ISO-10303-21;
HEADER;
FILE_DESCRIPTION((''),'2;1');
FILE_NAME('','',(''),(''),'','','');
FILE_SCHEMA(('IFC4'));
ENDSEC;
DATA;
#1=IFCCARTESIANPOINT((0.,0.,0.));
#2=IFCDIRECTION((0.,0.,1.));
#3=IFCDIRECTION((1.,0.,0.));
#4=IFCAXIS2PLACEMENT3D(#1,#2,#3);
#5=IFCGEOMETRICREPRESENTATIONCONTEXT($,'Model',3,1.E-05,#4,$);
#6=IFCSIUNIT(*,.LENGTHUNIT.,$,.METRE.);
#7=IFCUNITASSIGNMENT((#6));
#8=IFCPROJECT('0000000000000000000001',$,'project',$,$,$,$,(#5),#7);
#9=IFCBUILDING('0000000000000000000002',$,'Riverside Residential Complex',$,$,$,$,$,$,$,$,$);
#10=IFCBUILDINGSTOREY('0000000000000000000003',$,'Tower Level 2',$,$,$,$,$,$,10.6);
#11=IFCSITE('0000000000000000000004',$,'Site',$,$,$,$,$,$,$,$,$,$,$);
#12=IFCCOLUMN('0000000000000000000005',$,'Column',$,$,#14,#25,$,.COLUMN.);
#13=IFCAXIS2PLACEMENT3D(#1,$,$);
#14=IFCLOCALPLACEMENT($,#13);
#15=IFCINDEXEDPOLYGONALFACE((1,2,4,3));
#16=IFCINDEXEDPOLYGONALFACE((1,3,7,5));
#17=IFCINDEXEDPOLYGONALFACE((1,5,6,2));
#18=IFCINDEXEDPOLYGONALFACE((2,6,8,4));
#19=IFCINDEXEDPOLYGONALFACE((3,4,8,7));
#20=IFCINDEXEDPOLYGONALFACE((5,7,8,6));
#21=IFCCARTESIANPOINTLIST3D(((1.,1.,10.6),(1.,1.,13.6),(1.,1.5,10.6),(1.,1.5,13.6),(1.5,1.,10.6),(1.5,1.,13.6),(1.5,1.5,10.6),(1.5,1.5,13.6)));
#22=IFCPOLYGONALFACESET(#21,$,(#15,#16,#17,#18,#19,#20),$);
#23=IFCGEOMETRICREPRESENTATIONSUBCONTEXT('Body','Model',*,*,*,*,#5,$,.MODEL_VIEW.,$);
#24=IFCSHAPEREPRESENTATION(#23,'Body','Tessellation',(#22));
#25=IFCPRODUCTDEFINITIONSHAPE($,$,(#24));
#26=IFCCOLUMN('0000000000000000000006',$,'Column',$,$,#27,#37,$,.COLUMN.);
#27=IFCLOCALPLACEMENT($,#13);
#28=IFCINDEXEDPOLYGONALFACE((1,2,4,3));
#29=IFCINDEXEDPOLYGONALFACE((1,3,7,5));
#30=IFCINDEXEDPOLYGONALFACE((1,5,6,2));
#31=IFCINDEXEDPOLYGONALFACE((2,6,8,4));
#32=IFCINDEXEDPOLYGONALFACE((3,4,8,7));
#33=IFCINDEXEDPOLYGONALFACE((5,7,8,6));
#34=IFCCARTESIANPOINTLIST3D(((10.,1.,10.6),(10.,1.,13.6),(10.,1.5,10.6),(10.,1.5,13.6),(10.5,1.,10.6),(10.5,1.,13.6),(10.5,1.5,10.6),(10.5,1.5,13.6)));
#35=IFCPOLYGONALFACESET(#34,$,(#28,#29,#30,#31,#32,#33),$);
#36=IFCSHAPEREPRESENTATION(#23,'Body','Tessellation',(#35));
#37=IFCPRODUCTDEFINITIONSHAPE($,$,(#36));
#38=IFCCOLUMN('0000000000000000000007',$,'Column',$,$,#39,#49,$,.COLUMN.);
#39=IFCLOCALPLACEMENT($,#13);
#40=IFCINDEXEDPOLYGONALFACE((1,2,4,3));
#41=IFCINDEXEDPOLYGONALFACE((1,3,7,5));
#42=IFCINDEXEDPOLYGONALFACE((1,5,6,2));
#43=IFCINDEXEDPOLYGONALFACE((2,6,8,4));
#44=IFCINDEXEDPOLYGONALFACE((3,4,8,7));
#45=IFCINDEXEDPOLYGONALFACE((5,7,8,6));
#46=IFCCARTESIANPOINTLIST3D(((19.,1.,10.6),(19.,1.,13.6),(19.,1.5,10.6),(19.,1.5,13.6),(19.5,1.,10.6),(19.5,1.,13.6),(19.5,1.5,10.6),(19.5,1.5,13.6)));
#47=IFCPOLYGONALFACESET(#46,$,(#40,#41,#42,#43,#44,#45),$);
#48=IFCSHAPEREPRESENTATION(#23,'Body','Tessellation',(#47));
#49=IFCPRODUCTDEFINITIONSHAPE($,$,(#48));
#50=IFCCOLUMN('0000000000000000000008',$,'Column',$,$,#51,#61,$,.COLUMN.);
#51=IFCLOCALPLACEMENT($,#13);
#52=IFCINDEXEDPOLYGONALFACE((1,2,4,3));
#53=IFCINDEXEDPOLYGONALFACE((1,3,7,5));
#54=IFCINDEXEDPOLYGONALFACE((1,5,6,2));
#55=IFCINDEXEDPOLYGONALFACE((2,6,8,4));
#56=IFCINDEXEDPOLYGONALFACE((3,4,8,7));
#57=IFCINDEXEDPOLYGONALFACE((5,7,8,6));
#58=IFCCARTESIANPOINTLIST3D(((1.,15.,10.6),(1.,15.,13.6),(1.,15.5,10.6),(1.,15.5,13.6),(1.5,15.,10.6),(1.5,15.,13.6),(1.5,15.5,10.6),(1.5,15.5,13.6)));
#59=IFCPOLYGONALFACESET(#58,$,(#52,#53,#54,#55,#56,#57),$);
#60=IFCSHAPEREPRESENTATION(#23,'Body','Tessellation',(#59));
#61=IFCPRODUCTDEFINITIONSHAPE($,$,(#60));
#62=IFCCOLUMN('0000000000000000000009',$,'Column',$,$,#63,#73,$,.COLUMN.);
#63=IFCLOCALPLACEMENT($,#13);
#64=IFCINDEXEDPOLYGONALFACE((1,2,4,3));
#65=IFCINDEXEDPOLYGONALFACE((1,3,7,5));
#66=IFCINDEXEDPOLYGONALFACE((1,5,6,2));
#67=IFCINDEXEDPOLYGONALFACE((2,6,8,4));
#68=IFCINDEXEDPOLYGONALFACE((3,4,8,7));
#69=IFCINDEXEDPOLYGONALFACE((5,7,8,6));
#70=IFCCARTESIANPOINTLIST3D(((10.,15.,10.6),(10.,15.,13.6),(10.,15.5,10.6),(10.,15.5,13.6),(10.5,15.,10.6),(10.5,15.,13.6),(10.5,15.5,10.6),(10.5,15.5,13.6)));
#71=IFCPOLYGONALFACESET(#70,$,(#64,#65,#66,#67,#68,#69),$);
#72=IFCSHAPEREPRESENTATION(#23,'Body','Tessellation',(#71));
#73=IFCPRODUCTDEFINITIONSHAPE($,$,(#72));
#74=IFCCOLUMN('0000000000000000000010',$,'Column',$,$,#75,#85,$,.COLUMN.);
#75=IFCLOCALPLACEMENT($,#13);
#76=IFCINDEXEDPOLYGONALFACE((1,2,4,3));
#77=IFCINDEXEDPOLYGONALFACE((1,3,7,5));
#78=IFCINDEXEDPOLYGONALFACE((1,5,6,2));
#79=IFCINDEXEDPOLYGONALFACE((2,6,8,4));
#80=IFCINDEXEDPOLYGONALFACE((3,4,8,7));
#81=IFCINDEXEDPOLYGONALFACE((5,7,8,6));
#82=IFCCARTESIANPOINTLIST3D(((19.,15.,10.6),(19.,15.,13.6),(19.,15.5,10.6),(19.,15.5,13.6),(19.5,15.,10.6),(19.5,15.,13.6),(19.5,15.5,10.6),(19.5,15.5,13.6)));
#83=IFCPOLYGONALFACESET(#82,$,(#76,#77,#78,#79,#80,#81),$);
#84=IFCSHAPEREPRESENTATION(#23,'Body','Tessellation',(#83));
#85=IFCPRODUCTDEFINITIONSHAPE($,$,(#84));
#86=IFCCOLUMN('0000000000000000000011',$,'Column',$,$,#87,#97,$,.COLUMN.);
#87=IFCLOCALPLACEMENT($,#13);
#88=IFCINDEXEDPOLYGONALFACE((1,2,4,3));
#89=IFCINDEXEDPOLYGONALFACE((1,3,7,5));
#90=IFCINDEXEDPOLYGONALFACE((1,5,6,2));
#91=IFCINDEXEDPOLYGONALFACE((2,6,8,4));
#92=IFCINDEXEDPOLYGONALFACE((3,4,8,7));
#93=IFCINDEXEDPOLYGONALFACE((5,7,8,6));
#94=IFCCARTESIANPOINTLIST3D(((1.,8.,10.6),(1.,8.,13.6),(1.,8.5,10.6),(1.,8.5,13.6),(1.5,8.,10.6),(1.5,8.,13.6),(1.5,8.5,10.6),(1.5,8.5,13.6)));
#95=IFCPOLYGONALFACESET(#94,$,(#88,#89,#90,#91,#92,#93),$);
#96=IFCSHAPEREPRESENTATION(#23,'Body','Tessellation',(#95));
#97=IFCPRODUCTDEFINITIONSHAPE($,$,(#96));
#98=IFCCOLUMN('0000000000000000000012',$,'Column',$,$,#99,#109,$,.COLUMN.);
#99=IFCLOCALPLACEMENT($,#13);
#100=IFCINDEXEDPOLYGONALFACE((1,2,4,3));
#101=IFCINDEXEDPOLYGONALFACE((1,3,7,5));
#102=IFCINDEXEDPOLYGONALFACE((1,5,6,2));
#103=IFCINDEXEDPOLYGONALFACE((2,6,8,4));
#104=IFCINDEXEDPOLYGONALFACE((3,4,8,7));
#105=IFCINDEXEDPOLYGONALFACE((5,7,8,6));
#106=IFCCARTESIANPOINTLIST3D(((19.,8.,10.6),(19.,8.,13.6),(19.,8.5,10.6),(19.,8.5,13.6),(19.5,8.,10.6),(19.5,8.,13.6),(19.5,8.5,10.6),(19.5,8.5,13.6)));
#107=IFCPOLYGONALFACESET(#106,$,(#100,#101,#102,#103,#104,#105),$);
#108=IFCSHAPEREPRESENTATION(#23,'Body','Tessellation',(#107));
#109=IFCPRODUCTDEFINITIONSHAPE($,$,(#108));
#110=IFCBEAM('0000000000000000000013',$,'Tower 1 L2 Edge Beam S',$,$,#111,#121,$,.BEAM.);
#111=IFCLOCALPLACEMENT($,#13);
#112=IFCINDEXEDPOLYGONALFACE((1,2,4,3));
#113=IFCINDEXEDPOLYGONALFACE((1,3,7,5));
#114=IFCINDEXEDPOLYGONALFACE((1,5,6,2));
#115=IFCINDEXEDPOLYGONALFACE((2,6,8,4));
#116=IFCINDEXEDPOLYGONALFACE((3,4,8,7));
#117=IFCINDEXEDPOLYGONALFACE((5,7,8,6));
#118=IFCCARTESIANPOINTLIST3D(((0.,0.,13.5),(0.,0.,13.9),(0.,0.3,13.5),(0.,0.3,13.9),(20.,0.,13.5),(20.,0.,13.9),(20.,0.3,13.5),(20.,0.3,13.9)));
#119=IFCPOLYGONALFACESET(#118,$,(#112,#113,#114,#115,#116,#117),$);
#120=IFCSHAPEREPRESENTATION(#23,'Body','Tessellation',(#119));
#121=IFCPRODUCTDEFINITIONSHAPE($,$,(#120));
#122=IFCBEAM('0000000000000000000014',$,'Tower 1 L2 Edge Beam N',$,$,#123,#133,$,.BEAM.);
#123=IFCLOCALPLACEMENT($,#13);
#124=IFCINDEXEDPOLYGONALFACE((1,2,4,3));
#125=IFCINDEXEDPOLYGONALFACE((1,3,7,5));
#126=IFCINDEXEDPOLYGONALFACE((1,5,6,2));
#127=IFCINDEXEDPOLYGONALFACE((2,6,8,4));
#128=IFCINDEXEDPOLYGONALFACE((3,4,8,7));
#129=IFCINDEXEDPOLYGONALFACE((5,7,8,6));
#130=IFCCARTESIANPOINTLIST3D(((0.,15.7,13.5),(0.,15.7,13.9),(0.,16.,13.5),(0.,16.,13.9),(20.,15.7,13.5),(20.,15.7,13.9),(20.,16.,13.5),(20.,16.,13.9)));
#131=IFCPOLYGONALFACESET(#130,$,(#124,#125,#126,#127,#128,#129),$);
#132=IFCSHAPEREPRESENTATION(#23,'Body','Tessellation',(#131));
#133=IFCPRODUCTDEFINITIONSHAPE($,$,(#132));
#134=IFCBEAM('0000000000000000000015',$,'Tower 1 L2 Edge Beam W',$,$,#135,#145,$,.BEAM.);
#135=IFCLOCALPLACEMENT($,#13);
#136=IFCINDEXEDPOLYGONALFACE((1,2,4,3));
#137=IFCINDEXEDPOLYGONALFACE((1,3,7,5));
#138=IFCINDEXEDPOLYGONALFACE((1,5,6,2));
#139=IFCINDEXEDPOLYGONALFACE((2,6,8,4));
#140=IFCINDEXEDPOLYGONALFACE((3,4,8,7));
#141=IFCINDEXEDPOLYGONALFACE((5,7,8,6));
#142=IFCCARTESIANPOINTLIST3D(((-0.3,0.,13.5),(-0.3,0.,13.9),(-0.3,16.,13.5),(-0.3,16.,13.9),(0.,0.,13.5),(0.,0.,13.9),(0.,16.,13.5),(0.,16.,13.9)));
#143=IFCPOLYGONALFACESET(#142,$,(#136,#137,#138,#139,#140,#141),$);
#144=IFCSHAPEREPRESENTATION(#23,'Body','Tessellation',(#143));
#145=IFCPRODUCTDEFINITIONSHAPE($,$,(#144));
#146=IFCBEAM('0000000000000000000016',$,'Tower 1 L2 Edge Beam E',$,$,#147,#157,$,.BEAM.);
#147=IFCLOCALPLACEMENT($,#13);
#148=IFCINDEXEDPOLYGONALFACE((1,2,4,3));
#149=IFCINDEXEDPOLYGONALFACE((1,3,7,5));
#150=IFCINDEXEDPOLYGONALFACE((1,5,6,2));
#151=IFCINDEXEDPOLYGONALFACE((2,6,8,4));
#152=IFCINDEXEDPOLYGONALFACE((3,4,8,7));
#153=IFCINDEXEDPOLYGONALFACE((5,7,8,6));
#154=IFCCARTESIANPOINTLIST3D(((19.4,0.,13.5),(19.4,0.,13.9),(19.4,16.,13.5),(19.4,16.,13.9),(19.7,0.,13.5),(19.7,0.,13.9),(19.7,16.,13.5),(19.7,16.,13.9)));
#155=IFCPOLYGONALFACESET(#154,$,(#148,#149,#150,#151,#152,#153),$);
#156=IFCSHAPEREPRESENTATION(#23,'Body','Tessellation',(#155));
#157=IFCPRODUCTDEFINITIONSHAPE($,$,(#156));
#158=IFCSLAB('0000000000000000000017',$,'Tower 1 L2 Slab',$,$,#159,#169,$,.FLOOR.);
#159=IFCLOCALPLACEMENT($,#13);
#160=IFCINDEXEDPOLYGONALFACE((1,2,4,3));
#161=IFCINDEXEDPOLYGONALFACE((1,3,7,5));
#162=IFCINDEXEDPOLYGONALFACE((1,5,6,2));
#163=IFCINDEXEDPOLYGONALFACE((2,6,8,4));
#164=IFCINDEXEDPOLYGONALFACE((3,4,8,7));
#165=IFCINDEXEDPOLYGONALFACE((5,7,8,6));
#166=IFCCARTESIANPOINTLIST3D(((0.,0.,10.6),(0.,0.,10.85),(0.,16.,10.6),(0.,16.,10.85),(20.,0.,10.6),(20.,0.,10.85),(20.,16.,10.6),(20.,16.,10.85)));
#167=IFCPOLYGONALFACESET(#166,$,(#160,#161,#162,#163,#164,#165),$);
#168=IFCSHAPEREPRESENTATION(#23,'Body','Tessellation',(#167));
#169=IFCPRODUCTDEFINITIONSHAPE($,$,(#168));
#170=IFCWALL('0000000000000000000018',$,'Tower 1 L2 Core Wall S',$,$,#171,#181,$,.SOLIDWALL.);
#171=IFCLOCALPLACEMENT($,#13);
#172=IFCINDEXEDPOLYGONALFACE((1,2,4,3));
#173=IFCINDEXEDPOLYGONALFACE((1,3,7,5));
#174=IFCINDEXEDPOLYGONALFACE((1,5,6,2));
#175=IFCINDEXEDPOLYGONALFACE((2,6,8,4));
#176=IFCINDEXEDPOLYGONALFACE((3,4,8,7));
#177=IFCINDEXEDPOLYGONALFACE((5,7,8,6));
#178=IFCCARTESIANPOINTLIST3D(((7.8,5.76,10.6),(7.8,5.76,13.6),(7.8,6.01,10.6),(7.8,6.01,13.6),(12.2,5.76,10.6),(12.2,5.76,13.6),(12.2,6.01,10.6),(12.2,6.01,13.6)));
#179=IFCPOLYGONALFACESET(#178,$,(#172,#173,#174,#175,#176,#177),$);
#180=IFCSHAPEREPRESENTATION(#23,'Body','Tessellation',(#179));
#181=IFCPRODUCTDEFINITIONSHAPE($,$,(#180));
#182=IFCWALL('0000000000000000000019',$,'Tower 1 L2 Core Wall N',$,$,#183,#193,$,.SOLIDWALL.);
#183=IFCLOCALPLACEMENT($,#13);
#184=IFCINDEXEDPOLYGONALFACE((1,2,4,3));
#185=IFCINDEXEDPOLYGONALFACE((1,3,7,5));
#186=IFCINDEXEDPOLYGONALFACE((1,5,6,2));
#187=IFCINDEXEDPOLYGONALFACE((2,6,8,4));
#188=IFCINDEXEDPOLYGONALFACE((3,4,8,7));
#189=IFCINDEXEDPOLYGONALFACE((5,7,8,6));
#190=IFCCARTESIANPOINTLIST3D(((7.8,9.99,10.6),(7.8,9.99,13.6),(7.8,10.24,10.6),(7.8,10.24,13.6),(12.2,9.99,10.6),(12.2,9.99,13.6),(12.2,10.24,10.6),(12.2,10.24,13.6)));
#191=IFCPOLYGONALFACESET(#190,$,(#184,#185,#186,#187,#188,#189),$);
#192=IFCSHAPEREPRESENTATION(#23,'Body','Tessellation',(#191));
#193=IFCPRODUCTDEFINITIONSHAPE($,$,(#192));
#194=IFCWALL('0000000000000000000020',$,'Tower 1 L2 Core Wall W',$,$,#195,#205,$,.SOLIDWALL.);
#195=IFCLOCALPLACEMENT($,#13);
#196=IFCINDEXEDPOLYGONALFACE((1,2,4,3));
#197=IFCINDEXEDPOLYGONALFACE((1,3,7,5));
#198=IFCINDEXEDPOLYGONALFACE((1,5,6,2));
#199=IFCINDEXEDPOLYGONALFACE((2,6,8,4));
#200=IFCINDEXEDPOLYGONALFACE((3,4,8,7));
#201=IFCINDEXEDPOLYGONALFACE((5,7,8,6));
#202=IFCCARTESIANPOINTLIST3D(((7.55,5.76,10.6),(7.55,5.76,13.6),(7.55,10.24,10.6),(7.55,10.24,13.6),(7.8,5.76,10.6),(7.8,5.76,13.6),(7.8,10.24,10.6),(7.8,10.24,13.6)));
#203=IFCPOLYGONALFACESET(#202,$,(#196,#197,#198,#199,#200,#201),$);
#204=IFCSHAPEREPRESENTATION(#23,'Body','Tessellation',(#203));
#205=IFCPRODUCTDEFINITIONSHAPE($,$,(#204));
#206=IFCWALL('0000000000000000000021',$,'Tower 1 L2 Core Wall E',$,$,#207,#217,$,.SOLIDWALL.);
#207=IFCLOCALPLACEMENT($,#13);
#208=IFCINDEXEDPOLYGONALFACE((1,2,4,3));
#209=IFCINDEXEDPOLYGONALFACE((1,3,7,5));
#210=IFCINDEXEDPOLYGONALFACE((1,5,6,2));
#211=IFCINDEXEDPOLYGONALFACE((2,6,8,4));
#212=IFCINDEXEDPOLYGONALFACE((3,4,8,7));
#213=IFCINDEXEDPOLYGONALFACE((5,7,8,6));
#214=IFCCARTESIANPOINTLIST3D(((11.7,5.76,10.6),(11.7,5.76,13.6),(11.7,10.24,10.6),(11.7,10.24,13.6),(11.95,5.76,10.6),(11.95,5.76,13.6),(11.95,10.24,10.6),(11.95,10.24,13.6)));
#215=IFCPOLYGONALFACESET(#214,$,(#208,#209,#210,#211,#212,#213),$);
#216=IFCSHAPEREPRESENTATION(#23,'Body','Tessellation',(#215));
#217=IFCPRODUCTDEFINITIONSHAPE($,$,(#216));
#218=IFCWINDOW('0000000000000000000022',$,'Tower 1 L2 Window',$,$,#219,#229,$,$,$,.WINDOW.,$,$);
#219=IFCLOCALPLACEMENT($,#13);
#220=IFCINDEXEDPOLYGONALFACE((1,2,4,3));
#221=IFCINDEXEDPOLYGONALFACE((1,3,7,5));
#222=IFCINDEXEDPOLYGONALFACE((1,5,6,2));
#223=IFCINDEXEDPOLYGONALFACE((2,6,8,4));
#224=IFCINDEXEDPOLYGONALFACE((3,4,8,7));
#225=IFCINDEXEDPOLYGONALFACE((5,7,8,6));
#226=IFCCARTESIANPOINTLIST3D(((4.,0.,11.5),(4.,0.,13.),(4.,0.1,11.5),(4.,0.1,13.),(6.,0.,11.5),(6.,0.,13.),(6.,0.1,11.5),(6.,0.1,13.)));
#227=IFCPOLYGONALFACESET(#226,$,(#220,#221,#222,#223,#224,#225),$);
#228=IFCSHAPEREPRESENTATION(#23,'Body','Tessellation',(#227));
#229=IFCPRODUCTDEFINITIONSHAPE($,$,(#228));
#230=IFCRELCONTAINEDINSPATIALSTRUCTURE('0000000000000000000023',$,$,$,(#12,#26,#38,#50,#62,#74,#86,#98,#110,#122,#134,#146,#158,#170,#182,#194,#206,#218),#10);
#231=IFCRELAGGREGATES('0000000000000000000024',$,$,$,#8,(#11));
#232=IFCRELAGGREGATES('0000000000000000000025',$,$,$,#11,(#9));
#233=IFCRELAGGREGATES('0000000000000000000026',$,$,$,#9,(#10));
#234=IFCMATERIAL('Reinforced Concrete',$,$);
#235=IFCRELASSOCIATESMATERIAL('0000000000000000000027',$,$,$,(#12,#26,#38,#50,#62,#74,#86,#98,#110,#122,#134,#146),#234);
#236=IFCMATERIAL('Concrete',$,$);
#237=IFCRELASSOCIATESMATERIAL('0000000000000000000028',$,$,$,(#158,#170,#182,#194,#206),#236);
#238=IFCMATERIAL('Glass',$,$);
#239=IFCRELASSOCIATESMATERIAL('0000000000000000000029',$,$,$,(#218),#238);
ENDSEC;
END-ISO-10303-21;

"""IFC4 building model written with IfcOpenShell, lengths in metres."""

from ifc_helpers import new_model, si_unit, frame, origin_with_axes, place, context, subcontext, project, spatial, line, indexed_curve, outline, extrude, material, element, save


model = new_model("IFC4")

# Units and contexts
model_context = context("Model", 3, precision=1e-05, world=origin_with_axes())
body_context = subcontext(model_context, "Body", "Model", "MODEL_VIEW")
ifc_project = project(units=[si_unit("LENGTHUNIT", "METRE")], contexts=[model_context])

# Site, building, storey
site = spatial("IfcSite", under=ifc_project, Name="Site")
building = spatial("IfcBuilding", under=site, Name="Riverside Residential Complex")
storey = spatial("IfcBuildingStorey", under=building, Name="Tower Level 2", Elevation=10.6)

# Columns
ifc_material_1 = material(Name="Reinforced Concrete")
for number, where, z_axis, x_axis, name in (
    (1, (1.0, 1.0, 10.6), (0.0, 0.0, 1.0), (1.0, 0.0, 0.0), "Column"),
    (2, (10.0, 1.0, 10.6), (0.0, 0.0, 1.0), (1.0, 0.0, 0.0), "Column"),
    (3, (19.0, 1.0, 10.6), (0.0, 0.0, 1.0), (1.0, 0.0, 0.0), "Column"),
    (4, (1.0, 15.0, 10.6), (0.0, 0.0, 1.0), (1.0, 0.0, 0.0), "Column"),
    (5, (10.0, 15.0, 10.6), (0.0, 0.0, 1.0), (1.0, 0.0, 0.0), "Column"),
    (6, (19.0, 15.0, 10.6), (0.0, 0.0, 1.0), (1.0, 0.0, 0.0), "Column"),
    (7, (1.0, 8.0, 10.6), (0.0, 0.0, 1.0), (1.0, 0.0, 0.0), "Column"),
    (8, (19.0, 8.0, 10.6), (0.0, 0.0, 1.0), (1.0, 0.0, 0.0), "Column"),
):
    element("IfcColumn", number, at=place(None, frame(where, z_axis=z_axis, x_axis=x_axis)), inside=storey, material=ifc_material_1, Name=name, PredefinedType="COLUMN", context=body_context, shape_type="SweptSolid", body=[
        extrude(outline(indexed_curve([(0.0, 0.0), (0.5, 0.0), (0.5, 0.5), (0.0, 0.5)], segments=[line(1, 2, 3, 4, 1)])), origin_with_axes(), (0.0, 0.0, 1.0), 3.0),
    ])

# Beams
for number, where, z_axis, x_axis, name in (
    (9, (0.0, 0.0, 13.5), (0.0, 0.0, 1.0), (1.0, 0.0, 0.0), "Tower 1 L2 Edge Beam S"),
    (10, (0.0, 15.7, 13.5), (0.0, 0.0, 1.0), (1.0, 0.0, 0.0), "Tower 1 L2 Edge Beam N"),
):
    element("IfcBeam", number, at=place(None, frame(where, z_axis=z_axis, x_axis=x_axis)), inside=storey, material=ifc_material_1, Name=name, PredefinedType="BEAM", context=body_context, shape_type="SweptSolid", body=[
        extrude(outline(indexed_curve([(0.0, 0.0), (20.0, 0.0), (20.0, 0.3), (0.0, 0.3)], segments=[line(1, 2, 3, 4, 1)])), origin_with_axes(), (0.0, 0.0, 1.0), 0.4),
    ])
for number, where, z_axis, x_axis, name in (
    (11, (0.0, 0.0, 13.5), (0.0, 0.0, 1.0), (0.0, 1.0, 0.0), "Tower 1 L2 Edge Beam W"),
    (12, (19.7, 0.0, 13.5), (0.0, 0.0, 1.0), (0.0, 1.0, 0.0), "Tower 1 L2 Edge Beam E"),
):
    element("IfcBeam", number, at=place(None, frame(where, z_axis=z_axis, x_axis=x_axis)), inside=storey, material=ifc_material_1, Name=name, PredefinedType="BEAM", context=body_context, shape_type="SweptSolid", body=[
        extrude(outline(indexed_curve([(0.0, 0.0), (16.0, 0.0), (16.0, 0.3), (0.0, 0.3)], segments=[line(1, 2, 3, 4, 1)])), origin_with_axes(), (0.0, 0.0, 1.0), 0.4),
    ])

# Slab
ifc_material_2 = material(Name="Concrete")
slab_placement = place(None, frame((0.0, 0.0, 10.6), z_axis=(0.0, 0.0, 1.0), x_axis=(1.0, 0.0, 0.0)))
element("IfcSlab", 13, at=slab_placement, inside=storey, material=ifc_material_2, Name="Tower 1 L2 Slab", PredefinedType="FLOOR", context=body_context, shape_type="SweptSolid", body=[
    extrude(outline(indexed_curve([(0.0, 0.0), (20.0, 0.0), (20.0, 16.0), (0.0, 16.0)], segments=[line(1, 2, 3, 4, 1)])), origin_with_axes(), (0.0, 0.0, 1.0), 0.25),
])

# Walls
for number, where, z_axis, x_axis, name in (
    (14, (7.8, 5.76, 10.6), (0.0, 0.0, 1.0), (1.0, 0.0, 0.0), "Tower 1 L2 Core Wall S"),
    (15, (7.8, 9.99, 10.6), (0.0, 0.0, 1.0), (1.0, 0.0, 0.0), "Tower 1 L2 Core Wall N"),
):
    element("IfcWall", number, at=place(None, frame(where, z_axis=z_axis, x_axis=x_axis)), inside=storey, material=ifc_material_2, Name=name, PredefinedType="SOLIDWALL", context=body_context, shape_type="SweptSolid", body=[
        extrude(outline(indexed_curve([(0.0, 0.0), (4.4, 0.0), (4.4, 0.25), (0.0, 0.25)], segments=[line(1, 2, 3, 4, 1)])), origin_with_axes(), (0.0, 0.0, 1.0), 3.0),
    ])
for number, where, z_axis, x_axis, name in (
    (16, (7.8, 5.76, 10.6), (0.0, 0.0, 1.0), (0.0, 1.0, 0.0), "Tower 1 L2 Core Wall W"),
    (17, (11.95, 5.76, 10.6), (0.0, 0.0, 1.0), (0.0, 1.0, 0.0), "Tower 1 L2 Core Wall E"),
):
    element("IfcWall", number, at=place(None, frame(where, z_axis=z_axis, x_axis=x_axis)), inside=storey, material=ifc_material_2, Name=name, PredefinedType="SOLIDWALL", context=body_context, shape_type="SweptSolid", body=[
        extrude(outline(indexed_curve([(0.0, 0.0), (4.48, 0.0), (4.48, 0.25), (0.0, 0.25)], segments=[line(1, 2, 3, 4, 1)])), origin_with_axes(), (0.0, 0.0, 1.0), 3.0),
    ])

# Window
ifc_material_3 = material(Name="Glass")
for number, where, z_axis, x_axis, name in (
    (18, (4.0, 0.0, 11.5), (0.0, 0.0, 1.0), (1.0, 0.0, 0.0), "Tower 1 L2 Window"),
):
    element("IfcWindow", number, at=place(None, frame(where, z_axis=z_axis, x_axis=x_axis)), inside=storey, material=ifc_material_3, Name=name, PredefinedType="WINDOW", context=body_context, shape_type="SweptSolid", body=[
        extrude(outline(indexed_curve([(0.0, 0.0), (2.0, 0.0), (2.0, 0.1), (0.0, 0.1)], segments=[line(1, 2, 3, 4, 1)])), origin_with_axes(), (0.0, 0.0, 1.0), 1.5),
    ])

save(model, "model.ifc")
